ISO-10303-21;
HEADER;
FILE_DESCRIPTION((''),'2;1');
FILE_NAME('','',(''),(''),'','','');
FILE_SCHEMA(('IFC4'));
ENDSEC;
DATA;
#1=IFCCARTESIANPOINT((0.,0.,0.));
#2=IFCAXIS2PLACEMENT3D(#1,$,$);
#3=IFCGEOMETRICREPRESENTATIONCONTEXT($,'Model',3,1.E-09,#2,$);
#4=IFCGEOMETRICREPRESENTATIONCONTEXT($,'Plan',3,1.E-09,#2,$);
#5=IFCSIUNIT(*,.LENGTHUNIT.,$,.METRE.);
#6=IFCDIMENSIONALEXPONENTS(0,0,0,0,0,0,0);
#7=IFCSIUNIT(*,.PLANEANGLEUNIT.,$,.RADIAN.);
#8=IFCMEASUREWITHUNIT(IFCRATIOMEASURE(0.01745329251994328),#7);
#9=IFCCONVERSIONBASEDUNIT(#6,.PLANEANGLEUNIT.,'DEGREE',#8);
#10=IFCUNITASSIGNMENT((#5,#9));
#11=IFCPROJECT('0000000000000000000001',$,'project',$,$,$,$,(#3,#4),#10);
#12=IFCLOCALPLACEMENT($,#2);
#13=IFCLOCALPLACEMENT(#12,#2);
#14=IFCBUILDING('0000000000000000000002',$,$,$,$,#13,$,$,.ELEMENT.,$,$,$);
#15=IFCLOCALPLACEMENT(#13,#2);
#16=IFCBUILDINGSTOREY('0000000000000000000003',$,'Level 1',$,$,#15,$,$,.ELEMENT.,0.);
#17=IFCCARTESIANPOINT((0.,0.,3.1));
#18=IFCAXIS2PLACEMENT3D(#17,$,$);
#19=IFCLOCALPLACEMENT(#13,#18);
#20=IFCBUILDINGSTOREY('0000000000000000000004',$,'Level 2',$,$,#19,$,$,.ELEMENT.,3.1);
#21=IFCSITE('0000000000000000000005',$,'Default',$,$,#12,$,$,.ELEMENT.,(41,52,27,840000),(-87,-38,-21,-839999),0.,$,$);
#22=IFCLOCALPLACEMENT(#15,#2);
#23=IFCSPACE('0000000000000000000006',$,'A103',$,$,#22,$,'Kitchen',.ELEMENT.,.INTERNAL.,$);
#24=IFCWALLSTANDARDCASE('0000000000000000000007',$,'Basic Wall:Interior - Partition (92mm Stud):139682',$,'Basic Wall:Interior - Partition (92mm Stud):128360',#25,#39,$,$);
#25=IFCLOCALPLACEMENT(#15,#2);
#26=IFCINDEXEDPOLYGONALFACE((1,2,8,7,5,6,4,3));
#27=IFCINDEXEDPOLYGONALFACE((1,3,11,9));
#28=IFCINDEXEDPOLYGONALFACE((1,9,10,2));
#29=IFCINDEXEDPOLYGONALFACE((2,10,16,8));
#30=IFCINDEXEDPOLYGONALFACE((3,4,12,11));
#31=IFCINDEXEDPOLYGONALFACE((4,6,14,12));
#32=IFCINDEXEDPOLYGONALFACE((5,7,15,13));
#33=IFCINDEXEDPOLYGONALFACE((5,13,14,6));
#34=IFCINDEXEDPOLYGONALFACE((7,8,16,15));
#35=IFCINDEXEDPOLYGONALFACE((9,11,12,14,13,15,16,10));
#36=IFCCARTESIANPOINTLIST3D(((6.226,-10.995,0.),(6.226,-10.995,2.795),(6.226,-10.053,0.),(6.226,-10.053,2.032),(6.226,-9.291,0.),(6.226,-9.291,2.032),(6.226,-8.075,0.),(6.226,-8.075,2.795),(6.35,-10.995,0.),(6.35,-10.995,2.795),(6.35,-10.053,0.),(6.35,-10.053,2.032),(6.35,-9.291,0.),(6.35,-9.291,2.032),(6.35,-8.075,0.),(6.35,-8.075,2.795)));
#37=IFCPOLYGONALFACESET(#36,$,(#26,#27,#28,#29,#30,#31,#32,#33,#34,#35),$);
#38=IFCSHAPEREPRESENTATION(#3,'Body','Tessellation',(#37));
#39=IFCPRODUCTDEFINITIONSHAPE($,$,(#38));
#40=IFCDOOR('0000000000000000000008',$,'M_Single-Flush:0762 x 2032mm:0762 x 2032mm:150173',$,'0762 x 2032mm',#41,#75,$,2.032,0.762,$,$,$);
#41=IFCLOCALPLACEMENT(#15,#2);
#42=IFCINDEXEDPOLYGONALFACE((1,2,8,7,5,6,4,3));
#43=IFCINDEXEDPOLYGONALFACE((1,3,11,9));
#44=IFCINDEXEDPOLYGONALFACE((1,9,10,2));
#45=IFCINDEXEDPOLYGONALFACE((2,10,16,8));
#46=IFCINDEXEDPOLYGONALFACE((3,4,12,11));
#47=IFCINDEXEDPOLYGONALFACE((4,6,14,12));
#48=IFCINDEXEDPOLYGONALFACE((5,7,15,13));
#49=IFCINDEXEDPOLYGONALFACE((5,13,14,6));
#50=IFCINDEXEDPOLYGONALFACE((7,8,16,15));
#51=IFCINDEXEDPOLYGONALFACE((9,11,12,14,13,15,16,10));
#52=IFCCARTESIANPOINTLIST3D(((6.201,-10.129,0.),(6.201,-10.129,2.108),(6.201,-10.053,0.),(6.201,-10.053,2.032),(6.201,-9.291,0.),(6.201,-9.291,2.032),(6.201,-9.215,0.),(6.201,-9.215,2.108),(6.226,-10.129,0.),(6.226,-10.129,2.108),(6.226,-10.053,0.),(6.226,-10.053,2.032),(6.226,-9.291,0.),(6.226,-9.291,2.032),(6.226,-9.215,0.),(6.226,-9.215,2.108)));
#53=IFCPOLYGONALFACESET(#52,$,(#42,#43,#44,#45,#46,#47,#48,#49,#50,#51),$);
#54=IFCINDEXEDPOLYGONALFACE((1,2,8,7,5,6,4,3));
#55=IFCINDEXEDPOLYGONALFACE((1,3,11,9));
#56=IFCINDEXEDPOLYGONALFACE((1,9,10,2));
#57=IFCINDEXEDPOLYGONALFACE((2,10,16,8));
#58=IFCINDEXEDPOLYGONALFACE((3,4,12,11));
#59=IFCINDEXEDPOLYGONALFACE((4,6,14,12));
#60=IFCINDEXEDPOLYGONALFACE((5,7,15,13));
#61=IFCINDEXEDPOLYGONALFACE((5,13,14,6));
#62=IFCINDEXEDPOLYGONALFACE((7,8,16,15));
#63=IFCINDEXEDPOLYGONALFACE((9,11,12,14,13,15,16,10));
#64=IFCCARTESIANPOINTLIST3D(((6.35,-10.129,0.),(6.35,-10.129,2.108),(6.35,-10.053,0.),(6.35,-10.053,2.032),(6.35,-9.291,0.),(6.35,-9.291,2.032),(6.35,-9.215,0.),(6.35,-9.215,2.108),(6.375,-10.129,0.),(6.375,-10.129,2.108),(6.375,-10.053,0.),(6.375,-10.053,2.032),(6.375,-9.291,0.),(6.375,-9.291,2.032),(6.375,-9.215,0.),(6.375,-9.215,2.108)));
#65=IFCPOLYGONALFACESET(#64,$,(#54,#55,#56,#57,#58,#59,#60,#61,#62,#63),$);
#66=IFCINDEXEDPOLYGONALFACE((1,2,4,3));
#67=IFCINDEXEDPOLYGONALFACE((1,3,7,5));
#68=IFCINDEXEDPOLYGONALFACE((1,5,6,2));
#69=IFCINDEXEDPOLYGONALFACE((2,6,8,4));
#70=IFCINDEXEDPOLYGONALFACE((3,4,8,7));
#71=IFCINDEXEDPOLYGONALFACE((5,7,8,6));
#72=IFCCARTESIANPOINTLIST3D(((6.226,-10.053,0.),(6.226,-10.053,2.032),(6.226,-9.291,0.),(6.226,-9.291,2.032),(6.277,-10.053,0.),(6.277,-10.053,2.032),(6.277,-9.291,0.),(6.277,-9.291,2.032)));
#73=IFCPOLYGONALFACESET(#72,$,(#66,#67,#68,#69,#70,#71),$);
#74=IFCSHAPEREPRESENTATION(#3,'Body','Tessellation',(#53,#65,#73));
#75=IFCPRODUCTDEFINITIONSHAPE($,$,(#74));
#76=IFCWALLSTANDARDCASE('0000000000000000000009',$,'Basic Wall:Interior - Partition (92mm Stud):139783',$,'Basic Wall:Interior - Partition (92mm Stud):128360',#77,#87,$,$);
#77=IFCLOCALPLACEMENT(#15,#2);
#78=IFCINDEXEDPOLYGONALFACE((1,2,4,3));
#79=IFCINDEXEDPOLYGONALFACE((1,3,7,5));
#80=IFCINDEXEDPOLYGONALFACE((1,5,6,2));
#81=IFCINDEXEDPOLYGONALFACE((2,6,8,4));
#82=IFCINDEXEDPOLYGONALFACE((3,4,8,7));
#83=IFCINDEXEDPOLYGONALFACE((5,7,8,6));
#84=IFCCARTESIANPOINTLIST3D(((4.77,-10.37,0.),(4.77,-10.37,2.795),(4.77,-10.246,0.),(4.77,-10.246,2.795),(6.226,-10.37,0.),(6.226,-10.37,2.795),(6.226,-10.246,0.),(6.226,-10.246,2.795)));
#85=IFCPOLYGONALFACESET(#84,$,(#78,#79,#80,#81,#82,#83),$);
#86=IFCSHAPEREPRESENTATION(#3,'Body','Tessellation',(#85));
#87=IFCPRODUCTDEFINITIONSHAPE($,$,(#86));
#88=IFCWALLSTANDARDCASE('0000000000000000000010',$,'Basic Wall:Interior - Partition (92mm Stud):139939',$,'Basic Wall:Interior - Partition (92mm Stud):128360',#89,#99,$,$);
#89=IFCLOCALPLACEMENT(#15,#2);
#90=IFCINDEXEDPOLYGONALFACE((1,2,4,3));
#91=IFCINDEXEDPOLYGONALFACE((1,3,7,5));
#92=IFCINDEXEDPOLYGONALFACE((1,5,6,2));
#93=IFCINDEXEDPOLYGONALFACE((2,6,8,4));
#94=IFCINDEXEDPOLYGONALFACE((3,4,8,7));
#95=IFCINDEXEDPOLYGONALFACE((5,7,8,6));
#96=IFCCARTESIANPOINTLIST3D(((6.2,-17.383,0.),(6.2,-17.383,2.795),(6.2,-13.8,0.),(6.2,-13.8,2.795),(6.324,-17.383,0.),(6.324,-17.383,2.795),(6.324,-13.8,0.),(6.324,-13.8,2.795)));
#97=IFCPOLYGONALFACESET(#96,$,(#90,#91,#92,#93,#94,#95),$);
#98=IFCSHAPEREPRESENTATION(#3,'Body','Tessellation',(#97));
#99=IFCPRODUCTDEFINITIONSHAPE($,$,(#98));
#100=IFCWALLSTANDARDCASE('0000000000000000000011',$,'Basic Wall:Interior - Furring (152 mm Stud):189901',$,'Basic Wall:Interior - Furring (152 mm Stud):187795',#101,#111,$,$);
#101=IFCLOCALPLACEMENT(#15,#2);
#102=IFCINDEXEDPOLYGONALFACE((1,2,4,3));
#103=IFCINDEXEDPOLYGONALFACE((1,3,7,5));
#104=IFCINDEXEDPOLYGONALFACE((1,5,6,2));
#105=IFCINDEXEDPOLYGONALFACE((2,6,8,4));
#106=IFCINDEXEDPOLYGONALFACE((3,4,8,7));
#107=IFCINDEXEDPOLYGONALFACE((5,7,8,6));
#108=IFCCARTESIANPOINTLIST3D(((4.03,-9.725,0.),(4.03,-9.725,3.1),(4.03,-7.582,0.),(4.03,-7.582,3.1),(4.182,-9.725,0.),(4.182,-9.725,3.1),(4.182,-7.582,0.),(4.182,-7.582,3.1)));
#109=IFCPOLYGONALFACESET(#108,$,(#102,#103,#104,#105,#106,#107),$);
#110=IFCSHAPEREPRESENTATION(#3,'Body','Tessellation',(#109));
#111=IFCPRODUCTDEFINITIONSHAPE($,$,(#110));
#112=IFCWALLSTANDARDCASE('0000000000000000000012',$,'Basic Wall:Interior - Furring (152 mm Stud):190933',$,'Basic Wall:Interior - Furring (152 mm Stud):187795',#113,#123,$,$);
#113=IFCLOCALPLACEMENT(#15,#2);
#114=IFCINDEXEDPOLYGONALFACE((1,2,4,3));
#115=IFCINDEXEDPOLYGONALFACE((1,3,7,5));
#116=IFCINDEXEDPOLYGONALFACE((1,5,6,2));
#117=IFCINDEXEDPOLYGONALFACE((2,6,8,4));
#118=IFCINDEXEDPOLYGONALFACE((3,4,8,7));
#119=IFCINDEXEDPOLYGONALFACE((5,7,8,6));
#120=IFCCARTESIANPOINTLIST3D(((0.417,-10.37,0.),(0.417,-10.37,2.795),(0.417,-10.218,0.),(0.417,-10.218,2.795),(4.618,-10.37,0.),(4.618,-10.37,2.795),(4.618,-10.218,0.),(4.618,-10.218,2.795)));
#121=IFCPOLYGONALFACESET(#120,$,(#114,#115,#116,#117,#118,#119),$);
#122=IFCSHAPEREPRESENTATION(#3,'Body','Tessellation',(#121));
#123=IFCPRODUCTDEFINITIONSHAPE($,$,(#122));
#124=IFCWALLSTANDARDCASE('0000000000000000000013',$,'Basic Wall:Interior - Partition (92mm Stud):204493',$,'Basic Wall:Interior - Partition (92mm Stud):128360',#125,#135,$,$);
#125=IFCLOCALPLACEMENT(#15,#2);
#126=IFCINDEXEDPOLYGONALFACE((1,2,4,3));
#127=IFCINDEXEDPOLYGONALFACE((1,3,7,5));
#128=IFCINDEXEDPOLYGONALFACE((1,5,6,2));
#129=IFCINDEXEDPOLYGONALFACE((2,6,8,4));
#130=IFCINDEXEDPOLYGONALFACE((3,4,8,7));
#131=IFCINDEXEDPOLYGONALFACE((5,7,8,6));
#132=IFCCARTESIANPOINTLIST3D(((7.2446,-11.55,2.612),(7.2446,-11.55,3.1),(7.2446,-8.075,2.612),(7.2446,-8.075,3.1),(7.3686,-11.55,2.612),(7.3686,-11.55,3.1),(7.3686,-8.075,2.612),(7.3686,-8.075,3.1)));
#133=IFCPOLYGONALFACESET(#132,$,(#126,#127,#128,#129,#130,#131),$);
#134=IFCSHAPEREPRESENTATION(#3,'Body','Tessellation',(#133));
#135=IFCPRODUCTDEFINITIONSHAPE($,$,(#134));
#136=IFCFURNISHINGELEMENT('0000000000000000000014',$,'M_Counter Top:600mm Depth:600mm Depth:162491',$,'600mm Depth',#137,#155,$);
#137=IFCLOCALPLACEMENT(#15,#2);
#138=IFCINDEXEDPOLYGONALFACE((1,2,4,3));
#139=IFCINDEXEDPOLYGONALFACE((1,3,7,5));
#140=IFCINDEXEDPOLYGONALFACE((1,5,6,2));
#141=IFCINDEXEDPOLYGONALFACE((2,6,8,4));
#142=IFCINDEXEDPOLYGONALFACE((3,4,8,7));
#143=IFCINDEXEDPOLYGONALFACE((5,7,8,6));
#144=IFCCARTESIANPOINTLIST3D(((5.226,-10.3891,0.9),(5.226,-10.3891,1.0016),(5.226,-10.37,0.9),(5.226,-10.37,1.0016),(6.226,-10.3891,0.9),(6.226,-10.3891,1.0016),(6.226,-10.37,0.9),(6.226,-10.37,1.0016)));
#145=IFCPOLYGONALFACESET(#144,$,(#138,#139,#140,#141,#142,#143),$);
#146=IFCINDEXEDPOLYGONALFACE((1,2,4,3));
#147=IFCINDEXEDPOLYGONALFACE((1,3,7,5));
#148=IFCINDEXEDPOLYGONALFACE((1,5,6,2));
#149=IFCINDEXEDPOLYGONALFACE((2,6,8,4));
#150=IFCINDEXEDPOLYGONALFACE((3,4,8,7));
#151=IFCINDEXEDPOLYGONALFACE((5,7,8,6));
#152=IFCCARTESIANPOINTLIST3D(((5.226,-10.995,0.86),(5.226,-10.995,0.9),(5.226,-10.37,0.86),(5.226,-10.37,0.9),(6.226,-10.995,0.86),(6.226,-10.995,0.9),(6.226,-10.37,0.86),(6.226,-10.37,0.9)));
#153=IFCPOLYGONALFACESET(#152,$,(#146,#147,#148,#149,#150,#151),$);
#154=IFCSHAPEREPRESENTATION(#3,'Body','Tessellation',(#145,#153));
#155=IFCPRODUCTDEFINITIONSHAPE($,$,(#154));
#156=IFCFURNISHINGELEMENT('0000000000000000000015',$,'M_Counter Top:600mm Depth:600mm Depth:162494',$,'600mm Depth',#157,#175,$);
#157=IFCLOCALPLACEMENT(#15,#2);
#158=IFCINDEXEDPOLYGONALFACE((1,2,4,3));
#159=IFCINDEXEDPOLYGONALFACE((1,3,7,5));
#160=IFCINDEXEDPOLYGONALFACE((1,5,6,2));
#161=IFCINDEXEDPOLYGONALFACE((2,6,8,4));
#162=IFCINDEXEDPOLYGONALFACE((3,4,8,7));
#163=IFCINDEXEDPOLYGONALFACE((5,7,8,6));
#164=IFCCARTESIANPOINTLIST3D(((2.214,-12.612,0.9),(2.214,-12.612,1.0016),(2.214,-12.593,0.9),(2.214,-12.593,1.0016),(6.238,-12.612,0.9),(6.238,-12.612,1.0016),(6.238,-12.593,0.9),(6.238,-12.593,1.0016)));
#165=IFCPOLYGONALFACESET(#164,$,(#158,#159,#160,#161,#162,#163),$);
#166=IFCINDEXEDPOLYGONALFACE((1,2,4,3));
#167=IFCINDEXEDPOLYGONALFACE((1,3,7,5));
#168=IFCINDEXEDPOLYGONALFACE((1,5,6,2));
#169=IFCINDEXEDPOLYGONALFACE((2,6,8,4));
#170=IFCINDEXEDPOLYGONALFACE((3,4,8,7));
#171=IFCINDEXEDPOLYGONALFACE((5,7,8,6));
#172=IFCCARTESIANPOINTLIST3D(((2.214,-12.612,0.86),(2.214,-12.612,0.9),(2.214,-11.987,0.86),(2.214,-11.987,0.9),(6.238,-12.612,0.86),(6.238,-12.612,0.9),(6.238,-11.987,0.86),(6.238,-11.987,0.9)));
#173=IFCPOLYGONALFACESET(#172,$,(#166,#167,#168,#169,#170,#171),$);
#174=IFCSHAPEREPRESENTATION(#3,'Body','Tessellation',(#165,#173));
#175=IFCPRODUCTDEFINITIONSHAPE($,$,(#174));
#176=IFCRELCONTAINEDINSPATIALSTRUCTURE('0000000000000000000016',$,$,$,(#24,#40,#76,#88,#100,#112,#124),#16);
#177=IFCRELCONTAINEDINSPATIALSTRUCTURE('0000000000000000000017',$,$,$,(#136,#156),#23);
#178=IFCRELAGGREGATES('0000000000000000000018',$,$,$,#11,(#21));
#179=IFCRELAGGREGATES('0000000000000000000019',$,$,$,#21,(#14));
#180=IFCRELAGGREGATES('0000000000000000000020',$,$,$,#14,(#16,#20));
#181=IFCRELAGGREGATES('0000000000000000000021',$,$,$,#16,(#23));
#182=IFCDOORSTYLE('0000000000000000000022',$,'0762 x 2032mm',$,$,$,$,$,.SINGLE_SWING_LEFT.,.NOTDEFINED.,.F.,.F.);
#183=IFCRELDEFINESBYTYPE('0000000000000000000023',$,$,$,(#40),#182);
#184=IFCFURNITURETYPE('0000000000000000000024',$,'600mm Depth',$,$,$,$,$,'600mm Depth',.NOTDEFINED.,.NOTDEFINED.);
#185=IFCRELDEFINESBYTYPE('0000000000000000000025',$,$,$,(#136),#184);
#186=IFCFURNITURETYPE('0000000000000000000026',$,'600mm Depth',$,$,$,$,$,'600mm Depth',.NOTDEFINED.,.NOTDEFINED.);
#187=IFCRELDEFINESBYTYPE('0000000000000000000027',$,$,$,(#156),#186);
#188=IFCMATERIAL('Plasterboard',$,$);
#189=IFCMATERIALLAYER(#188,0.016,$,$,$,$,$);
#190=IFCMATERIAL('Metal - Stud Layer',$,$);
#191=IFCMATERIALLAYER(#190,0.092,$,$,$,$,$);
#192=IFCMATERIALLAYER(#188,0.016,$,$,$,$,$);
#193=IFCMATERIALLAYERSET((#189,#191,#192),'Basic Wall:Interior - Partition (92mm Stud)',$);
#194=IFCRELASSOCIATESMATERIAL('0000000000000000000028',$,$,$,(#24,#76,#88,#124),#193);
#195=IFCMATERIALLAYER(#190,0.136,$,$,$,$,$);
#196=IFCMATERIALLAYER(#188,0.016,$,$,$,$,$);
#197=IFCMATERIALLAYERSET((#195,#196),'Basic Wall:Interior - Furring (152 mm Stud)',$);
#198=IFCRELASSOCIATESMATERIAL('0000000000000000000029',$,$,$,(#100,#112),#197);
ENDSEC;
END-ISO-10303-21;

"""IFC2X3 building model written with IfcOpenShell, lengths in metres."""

from ifc_helpers import new_model, entity, si_unit, converted_unit, frame, frame_2d, origin, origin_2d_with_axis, place, context, project, spatial, polyline, rectangle, outline, extrude, source, transform, mapped, material, layer, layer_set, layer_usage, type_object, type_shapes, element, fill, save


model = new_model("IFC2X3")

# Units and contexts
model_context = context("Model", 3, precision=1e-09, world=origin())
plan_context = context("Plan", 3, precision=1e-09, world=origin())
ifc_project = project(units=[si_unit("LENGTHUNIT", "METRE"), converted_unit("PLANEANGLEUNIT", "DEGREE", entity("IfcRatioMeasure", 0.01745329251994328), si_unit("PLANEANGLEUNIT", "RADIAN"), dimensions=[0, 0, 0, 0, 0, 0, 0])], contexts=[model_context, plan_context])

# Site, building, storey
site_placement = place(None, origin())
site = spatial("IfcSite", under=ifc_project, at=site_placement, Name="Default", CompositionType="ELEMENT", RefLatitude=(41, 52, 27, 840000), RefLongitude=(-87, -38, -21, -839999), RefElevation=0.0)
building_placement = place(site_placement, origin())
building = spatial("IfcBuilding", under=site, at=building_placement, CompositionType="ELEMENT")
storey_1_placement = place(building_placement, origin())
storey_1 = spatial("IfcBuildingStorey", under=building, at=storey_1_placement, Name="Level 1", CompositionType="ELEMENT", Elevation=0.0)

# Shared definitions
ifc_material_1 = material(Name="Metal - Stud Layer")
ifc_material_2 = material(Name="Plasterboard")

# Wall, opening, door
ifc_layer_1 = layer(ifc_material_2, 0.016)
ifc_layer_2 = layer(ifc_material_1, 0.092)
ifc_layer_3 = layer(ifc_material_2, 0.016)
ifc_layer_set_1 = layer_set([ifc_layer_1, ifc_layer_2, ifc_layer_3], Name="Basic Wall:Interior - Partition (92mm Stud)")
ifc_layer_usage_1 = layer_usage(ifc_layer_set_1, "AXIS2", "NEGATIVE", 0.062)
wall_1_placement = place(storey_1_placement, frame((6.288, -10.995, 0.0), z_axis=(0.0, 0.0, 1.0), x_axis=(0.0, 1.0, 0.0)))
wall_1 = element("IfcWallStandardCase", 1, at=wall_1_placement, inside=storey_1, material=ifc_layer_usage_1, Name="Basic Wall:Interior - Partition (92mm Stud):139682", ObjectType="Basic Wall:Interior - Partition (92mm Stud):128360", context=model_context, shape_type="SweptSolid", body=[
    extrude(rectangle(XDim=2.92, YDim=0.124, at=frame_2d((1.46, 0.0), x_axis=(-1.0, 0.0))), origin(), (0.0, 0.0, 1.0), 2.795),
])
opening_1_placement = place(wall_1_placement, frame((0.942, -0.062, 0.0)))
opening_1 = element("IfcOpeningElement", 2, at=opening_1_placement, cuts=wall_1, ObjectType="Opening", context=model_context, shape_type="SweptSolid", body=[
    extrude(rectangle(XDim=0.762, YDim=2.032, at=frame_2d((1.016, 0.381), x_axis=(0.0, -1.0))), frame((0.0, 0.0, 0.0), z_axis=(0.0, 1.0, 0.0), x_axis=(0.0, 0.0, 1.0)), (0.0, 0.0, 1.0), 0.124),
])
door_style_1 = type_object("IfcDoorStyle", Name="0762 x 2032mm", ConstructionType="NOTDEFINED", OperationType="SINGLE_SWING_LEFT", ParameterTakesPrecedence=False, Sizeable=False)
shared_shape_1 = source(origin(), model_context, "Body", "SweptSolid", [
    extrude(outline(polyline([(-0.457, -1.073), (0.457, -1.073), (0.457, 1.035), (0.381, 1.035), (0.381, -0.997), (-0.381, -0.997), (-0.381, 1.035), (-0.457, 1.035), (-0.457, -1.073)])), frame((0.381, 0.149, 1.035), z_axis=(0.0, -1.0, 0.0), x_axis=(-1.0, 0.0, 0.0)), (0.0, 0.0, 1.0), 0.025),
    extrude(outline(polyline([(-1.073, -0.457), (1.035, -0.457), (1.035, -0.381), (-0.997, -0.381), (-0.997, 0.381), (1.035, 0.381), (1.035, 0.457), (-1.073, 0.457), (-1.073, -0.457)])), frame((0.381, 0.0, 1.035), z_axis=(0.0, -1.0, 0.0), x_axis=(0.0, 0.0, -1.0)), (0.0, 0.0, 1.0), 0.025),
    extrude(rectangle(XDim=0.762, YDim=0.051, at=origin_2d_with_axis()), frame((0.381, 0.0985, 0.0)), (0.0, 0.0, 1.0), 2.032),
])
type_shapes(door_style_1, [shared_shape_1])
door_1_placement = place(opening_1_placement, origin())
door_1 = element("IfcDoor", 3, at=door_1_placement, inside=storey_1, type_object=door_style_1, Name="M_Single-Flush:0762 x 2032mm:0762 x 2032mm:150173", ObjectType="0762 x 2032mm", OverallHeight=2.032, OverallWidth=0.762, context=model_context, shape_type="MappedRepresentation", body=[
    mapped(shared_shape_1, transform((0.0, 0.0, 0.0), scale=1.0)),
])
fill(opening_1, door_1)

# Walls
ifc_layer_usage_2 = layer_usage(ifc_layer_set_1, "AXIS2", "NEGATIVE", 0.062)
wall_2_placement = place(storey_1_placement, frame((4.77, -10.308, 0.0)))
element("IfcWallStandardCase", 4, at=wall_2_placement, inside=storey_1, material=ifc_layer_usage_2, Name="Basic Wall:Interior - Partition (92mm Stud):139783", ObjectType="Basic Wall:Interior - Partition (92mm Stud):128360", context=model_context, shape_type="SweptSolid", body=[
    extrude(rectangle(XDim=1.456, YDim=0.124, at=frame_2d((0.728, 0.0), x_axis=(-1.0, 0.0))), origin(), (0.0, 0.0, 1.0), 2.795),
])
ifc_layer_usage_3 = layer_usage(ifc_layer_set_1, "AXIS2", "NEGATIVE", 0.062)
wall_3_placement = place(storey_1_placement, frame((6.262, -13.8, 0.0), z_axis=(0.0, 0.0, 1.0), x_axis=(0.0, -1.0, 0.0)))
element("IfcWallStandardCase", 5, at=wall_3_placement, inside=storey_1, material=ifc_layer_usage_3, Name="Basic Wall:Interior - Partition (92mm Stud):139939", ObjectType="Basic Wall:Interior - Partition (92mm Stud):128360", context=model_context, shape_type="SweptSolid", body=[
    extrude(rectangle(XDim=3.583, YDim=0.124, at=frame_2d((1.7915, 0.0), x_axis=(-1.0, 0.0))), origin(), (0.0, 0.0, 1.0), 2.795),
])

# Shared definitions
storey_2_placement = place(building_placement, frame((0.0, 0.0, 3.1)))
storey_2 = spatial("IfcBuildingStorey", under=building, at=storey_2_placement, Name="Level 2", CompositionType="ELEMENT", Elevation=3.1)

# Walls
ifc_layer_4 = layer(ifc_material_1, 0.136)
ifc_layer_5 = layer(ifc_material_2, 0.016)
ifc_layer_set_2 = layer_set([ifc_layer_4, ifc_layer_5], Name="Basic Wall:Interior - Furring (152 mm Stud)")
ifc_layer_usage_4 = layer_usage(ifc_layer_set_2, "AXIS2", "POSITIVE", -0.076)
wall_4_placement = place(storey_1_placement, frame((4.106, -9.725, 0.0), z_axis=(0.0, 0.0, 1.0), x_axis=(0.0, 1.0, 0.0)))
element("IfcWallStandardCase", 6, at=wall_4_placement, inside=storey_1, material=ifc_layer_usage_4, Name="Basic Wall:Interior - Furring (152 mm Stud):189901", ObjectType="Basic Wall:Interior - Furring (152 mm Stud):187795", context=model_context, shape_type="SweptSolid", body=[
    extrude(rectangle(XDim=2.143, YDim=0.152, at=frame_2d((1.0715, 0.0), x_axis=(-1.0, 0.0))), origin(), (0.0, 0.0, 1.0), 3.1),
])
ifc_layer_usage_5 = layer_usage(ifc_layer_set_2, "AXIS2", "NEGATIVE", 0.076)
wall_5_placement = place(storey_1_placement, frame((0.417, -10.294, 0.0)))
element("IfcWallStandardCase", 7, at=wall_5_placement, inside=storey_1, material=ifc_layer_usage_5, Name="Basic Wall:Interior - Furring (152 mm Stud):190933", ObjectType="Basic Wall:Interior - Furring (152 mm Stud):187795", context=model_context, shape_type="SweptSolid", body=[
    extrude(rectangle(XDim=4.201, YDim=0.152, at=frame_2d((2.1005, 0.0), x_axis=(-1.0, 0.0))), origin(), (0.0, 0.0, 1.0), 2.795),
])
ifc_layer_usage_6 = layer_usage(ifc_layer_set_1, "AXIS2", "NEGATIVE", 0.062)
wall_6_placement = place(storey_1_placement, frame((7.3066, -11.55, 2.612), z_axis=(0.0, 0.0, 1.0), x_axis=(0.0, 1.0, 0.0)))
element("IfcWallStandardCase", 8, at=wall_6_placement, inside=storey_1, material=ifc_layer_usage_6, Name="Basic Wall:Interior - Partition (92mm Stud):204493", ObjectType="Basic Wall:Interior - Partition (92mm Stud):128360", context=model_context, shape_type="SweptSolid", body=[
    extrude(rectangle(XDim=3.475, YDim=0.124, at=frame_2d((1.7375, 0.0), x_axis=(-1.0, 0.0))), origin(), (0.0, 0.0, 1.0), 0.488),
])

# Shared definitions
space_1_placement = place(storey_1_placement, origin())
space_1 = spatial("IfcSpace", under=storey_1, at=space_1_placement, Name="A103", LongName="Kitchen", CompositionType="ELEMENT", InteriorOrExteriorSpace="INTERNAL")

# Furnishing elements
furniture_type_1 = type_object("IfcFurnitureType", Name="600mm Depth", ElementType="600mm Depth", AssemblyPlace="NOTDEFINED")
shared_shape_2 = source(origin(), model_context, "Body", "SweptSolid", [
    extrude(rectangle(XDim=0.0191, YDim=1.0, at=origin_2d_with_axis()), frame((-0.7005, -0.0095, 0.9), z_axis=(0.0, 0.0, 1.0), x_axis=(0.0, -1.0, 0.0)), (0.0, 0.0, 1.0), 0.1016),
    extrude(rectangle(XDim=1.0, YDim=0.625, at=origin_2d_with_axis()), frame((-0.7005, -0.3125, 0.86), z_axis=(0.0, 0.0, 1.0), x_axis=(-1.0, 0.0, 0.0)), (0.0, 0.0, 1.0), 0.04),
])
type_shapes(furniture_type_1, [shared_shape_2])
furnishing_1_placement = place(space_1_placement, frame((6.4265, -10.37, 0.0)))
element("IfcFurnishingElement", 9, at=furnishing_1_placement, inside=space_1, type_object=furniture_type_1, Name="M_Counter Top:600mm Depth:600mm Depth:162491", ObjectType="600mm Depth", context=model_context, shape_type="MappedRepresentation", body=[
    mapped(shared_shape_2, transform((0.0, 0.0, 0.0), scale=1.0)),
])
furniture_type_2 = type_object("IfcFurnitureType", Name="600mm Depth", ElementType="600mm Depth", AssemblyPlace="NOTDEFINED")
shared_shape_3 = source(origin(), model_context, "Body", "SweptSolid", [
    extrude(rectangle(XDim=0.0191, YDim=4.024, at=origin_2d_with_axis()), frame((0.8115, -0.0095, 0.9), z_axis=(0.0, 0.0, 1.0), x_axis=(0.0, -1.0, 0.0)), (0.0, 0.0, 1.0), 0.1016),
    extrude(rectangle(XDim=4.024, YDim=0.625, at=origin_2d_with_axis()), frame((0.8115, -0.3125, 0.86), z_axis=(0.0, 0.0, 1.0), x_axis=(-1.0, 0.0, 0.0)), (0.0, 0.0, 1.0), 0.04),
])
type_shapes(furniture_type_2, [shared_shape_3])
furnishing_2_placement = place(space_1_placement, frame((5.0375, -12.612, 0.0), z_axis=(0.0, 0.0, 1.0), x_axis=(-1.0, 0.0, 0.0)))
element("IfcFurnishingElement", 10, at=furnishing_2_placement, inside=space_1, type_object=furniture_type_2, Name="M_Counter Top:600mm Depth:600mm Depth:162494", ObjectType="600mm Depth", context=model_context, shape_type="MappedRepresentation", body=[
    mapped(shared_shape_3, transform((0.0, 0.0, 0.0), scale=1.0)),
])

save(model, "model.ifc")
